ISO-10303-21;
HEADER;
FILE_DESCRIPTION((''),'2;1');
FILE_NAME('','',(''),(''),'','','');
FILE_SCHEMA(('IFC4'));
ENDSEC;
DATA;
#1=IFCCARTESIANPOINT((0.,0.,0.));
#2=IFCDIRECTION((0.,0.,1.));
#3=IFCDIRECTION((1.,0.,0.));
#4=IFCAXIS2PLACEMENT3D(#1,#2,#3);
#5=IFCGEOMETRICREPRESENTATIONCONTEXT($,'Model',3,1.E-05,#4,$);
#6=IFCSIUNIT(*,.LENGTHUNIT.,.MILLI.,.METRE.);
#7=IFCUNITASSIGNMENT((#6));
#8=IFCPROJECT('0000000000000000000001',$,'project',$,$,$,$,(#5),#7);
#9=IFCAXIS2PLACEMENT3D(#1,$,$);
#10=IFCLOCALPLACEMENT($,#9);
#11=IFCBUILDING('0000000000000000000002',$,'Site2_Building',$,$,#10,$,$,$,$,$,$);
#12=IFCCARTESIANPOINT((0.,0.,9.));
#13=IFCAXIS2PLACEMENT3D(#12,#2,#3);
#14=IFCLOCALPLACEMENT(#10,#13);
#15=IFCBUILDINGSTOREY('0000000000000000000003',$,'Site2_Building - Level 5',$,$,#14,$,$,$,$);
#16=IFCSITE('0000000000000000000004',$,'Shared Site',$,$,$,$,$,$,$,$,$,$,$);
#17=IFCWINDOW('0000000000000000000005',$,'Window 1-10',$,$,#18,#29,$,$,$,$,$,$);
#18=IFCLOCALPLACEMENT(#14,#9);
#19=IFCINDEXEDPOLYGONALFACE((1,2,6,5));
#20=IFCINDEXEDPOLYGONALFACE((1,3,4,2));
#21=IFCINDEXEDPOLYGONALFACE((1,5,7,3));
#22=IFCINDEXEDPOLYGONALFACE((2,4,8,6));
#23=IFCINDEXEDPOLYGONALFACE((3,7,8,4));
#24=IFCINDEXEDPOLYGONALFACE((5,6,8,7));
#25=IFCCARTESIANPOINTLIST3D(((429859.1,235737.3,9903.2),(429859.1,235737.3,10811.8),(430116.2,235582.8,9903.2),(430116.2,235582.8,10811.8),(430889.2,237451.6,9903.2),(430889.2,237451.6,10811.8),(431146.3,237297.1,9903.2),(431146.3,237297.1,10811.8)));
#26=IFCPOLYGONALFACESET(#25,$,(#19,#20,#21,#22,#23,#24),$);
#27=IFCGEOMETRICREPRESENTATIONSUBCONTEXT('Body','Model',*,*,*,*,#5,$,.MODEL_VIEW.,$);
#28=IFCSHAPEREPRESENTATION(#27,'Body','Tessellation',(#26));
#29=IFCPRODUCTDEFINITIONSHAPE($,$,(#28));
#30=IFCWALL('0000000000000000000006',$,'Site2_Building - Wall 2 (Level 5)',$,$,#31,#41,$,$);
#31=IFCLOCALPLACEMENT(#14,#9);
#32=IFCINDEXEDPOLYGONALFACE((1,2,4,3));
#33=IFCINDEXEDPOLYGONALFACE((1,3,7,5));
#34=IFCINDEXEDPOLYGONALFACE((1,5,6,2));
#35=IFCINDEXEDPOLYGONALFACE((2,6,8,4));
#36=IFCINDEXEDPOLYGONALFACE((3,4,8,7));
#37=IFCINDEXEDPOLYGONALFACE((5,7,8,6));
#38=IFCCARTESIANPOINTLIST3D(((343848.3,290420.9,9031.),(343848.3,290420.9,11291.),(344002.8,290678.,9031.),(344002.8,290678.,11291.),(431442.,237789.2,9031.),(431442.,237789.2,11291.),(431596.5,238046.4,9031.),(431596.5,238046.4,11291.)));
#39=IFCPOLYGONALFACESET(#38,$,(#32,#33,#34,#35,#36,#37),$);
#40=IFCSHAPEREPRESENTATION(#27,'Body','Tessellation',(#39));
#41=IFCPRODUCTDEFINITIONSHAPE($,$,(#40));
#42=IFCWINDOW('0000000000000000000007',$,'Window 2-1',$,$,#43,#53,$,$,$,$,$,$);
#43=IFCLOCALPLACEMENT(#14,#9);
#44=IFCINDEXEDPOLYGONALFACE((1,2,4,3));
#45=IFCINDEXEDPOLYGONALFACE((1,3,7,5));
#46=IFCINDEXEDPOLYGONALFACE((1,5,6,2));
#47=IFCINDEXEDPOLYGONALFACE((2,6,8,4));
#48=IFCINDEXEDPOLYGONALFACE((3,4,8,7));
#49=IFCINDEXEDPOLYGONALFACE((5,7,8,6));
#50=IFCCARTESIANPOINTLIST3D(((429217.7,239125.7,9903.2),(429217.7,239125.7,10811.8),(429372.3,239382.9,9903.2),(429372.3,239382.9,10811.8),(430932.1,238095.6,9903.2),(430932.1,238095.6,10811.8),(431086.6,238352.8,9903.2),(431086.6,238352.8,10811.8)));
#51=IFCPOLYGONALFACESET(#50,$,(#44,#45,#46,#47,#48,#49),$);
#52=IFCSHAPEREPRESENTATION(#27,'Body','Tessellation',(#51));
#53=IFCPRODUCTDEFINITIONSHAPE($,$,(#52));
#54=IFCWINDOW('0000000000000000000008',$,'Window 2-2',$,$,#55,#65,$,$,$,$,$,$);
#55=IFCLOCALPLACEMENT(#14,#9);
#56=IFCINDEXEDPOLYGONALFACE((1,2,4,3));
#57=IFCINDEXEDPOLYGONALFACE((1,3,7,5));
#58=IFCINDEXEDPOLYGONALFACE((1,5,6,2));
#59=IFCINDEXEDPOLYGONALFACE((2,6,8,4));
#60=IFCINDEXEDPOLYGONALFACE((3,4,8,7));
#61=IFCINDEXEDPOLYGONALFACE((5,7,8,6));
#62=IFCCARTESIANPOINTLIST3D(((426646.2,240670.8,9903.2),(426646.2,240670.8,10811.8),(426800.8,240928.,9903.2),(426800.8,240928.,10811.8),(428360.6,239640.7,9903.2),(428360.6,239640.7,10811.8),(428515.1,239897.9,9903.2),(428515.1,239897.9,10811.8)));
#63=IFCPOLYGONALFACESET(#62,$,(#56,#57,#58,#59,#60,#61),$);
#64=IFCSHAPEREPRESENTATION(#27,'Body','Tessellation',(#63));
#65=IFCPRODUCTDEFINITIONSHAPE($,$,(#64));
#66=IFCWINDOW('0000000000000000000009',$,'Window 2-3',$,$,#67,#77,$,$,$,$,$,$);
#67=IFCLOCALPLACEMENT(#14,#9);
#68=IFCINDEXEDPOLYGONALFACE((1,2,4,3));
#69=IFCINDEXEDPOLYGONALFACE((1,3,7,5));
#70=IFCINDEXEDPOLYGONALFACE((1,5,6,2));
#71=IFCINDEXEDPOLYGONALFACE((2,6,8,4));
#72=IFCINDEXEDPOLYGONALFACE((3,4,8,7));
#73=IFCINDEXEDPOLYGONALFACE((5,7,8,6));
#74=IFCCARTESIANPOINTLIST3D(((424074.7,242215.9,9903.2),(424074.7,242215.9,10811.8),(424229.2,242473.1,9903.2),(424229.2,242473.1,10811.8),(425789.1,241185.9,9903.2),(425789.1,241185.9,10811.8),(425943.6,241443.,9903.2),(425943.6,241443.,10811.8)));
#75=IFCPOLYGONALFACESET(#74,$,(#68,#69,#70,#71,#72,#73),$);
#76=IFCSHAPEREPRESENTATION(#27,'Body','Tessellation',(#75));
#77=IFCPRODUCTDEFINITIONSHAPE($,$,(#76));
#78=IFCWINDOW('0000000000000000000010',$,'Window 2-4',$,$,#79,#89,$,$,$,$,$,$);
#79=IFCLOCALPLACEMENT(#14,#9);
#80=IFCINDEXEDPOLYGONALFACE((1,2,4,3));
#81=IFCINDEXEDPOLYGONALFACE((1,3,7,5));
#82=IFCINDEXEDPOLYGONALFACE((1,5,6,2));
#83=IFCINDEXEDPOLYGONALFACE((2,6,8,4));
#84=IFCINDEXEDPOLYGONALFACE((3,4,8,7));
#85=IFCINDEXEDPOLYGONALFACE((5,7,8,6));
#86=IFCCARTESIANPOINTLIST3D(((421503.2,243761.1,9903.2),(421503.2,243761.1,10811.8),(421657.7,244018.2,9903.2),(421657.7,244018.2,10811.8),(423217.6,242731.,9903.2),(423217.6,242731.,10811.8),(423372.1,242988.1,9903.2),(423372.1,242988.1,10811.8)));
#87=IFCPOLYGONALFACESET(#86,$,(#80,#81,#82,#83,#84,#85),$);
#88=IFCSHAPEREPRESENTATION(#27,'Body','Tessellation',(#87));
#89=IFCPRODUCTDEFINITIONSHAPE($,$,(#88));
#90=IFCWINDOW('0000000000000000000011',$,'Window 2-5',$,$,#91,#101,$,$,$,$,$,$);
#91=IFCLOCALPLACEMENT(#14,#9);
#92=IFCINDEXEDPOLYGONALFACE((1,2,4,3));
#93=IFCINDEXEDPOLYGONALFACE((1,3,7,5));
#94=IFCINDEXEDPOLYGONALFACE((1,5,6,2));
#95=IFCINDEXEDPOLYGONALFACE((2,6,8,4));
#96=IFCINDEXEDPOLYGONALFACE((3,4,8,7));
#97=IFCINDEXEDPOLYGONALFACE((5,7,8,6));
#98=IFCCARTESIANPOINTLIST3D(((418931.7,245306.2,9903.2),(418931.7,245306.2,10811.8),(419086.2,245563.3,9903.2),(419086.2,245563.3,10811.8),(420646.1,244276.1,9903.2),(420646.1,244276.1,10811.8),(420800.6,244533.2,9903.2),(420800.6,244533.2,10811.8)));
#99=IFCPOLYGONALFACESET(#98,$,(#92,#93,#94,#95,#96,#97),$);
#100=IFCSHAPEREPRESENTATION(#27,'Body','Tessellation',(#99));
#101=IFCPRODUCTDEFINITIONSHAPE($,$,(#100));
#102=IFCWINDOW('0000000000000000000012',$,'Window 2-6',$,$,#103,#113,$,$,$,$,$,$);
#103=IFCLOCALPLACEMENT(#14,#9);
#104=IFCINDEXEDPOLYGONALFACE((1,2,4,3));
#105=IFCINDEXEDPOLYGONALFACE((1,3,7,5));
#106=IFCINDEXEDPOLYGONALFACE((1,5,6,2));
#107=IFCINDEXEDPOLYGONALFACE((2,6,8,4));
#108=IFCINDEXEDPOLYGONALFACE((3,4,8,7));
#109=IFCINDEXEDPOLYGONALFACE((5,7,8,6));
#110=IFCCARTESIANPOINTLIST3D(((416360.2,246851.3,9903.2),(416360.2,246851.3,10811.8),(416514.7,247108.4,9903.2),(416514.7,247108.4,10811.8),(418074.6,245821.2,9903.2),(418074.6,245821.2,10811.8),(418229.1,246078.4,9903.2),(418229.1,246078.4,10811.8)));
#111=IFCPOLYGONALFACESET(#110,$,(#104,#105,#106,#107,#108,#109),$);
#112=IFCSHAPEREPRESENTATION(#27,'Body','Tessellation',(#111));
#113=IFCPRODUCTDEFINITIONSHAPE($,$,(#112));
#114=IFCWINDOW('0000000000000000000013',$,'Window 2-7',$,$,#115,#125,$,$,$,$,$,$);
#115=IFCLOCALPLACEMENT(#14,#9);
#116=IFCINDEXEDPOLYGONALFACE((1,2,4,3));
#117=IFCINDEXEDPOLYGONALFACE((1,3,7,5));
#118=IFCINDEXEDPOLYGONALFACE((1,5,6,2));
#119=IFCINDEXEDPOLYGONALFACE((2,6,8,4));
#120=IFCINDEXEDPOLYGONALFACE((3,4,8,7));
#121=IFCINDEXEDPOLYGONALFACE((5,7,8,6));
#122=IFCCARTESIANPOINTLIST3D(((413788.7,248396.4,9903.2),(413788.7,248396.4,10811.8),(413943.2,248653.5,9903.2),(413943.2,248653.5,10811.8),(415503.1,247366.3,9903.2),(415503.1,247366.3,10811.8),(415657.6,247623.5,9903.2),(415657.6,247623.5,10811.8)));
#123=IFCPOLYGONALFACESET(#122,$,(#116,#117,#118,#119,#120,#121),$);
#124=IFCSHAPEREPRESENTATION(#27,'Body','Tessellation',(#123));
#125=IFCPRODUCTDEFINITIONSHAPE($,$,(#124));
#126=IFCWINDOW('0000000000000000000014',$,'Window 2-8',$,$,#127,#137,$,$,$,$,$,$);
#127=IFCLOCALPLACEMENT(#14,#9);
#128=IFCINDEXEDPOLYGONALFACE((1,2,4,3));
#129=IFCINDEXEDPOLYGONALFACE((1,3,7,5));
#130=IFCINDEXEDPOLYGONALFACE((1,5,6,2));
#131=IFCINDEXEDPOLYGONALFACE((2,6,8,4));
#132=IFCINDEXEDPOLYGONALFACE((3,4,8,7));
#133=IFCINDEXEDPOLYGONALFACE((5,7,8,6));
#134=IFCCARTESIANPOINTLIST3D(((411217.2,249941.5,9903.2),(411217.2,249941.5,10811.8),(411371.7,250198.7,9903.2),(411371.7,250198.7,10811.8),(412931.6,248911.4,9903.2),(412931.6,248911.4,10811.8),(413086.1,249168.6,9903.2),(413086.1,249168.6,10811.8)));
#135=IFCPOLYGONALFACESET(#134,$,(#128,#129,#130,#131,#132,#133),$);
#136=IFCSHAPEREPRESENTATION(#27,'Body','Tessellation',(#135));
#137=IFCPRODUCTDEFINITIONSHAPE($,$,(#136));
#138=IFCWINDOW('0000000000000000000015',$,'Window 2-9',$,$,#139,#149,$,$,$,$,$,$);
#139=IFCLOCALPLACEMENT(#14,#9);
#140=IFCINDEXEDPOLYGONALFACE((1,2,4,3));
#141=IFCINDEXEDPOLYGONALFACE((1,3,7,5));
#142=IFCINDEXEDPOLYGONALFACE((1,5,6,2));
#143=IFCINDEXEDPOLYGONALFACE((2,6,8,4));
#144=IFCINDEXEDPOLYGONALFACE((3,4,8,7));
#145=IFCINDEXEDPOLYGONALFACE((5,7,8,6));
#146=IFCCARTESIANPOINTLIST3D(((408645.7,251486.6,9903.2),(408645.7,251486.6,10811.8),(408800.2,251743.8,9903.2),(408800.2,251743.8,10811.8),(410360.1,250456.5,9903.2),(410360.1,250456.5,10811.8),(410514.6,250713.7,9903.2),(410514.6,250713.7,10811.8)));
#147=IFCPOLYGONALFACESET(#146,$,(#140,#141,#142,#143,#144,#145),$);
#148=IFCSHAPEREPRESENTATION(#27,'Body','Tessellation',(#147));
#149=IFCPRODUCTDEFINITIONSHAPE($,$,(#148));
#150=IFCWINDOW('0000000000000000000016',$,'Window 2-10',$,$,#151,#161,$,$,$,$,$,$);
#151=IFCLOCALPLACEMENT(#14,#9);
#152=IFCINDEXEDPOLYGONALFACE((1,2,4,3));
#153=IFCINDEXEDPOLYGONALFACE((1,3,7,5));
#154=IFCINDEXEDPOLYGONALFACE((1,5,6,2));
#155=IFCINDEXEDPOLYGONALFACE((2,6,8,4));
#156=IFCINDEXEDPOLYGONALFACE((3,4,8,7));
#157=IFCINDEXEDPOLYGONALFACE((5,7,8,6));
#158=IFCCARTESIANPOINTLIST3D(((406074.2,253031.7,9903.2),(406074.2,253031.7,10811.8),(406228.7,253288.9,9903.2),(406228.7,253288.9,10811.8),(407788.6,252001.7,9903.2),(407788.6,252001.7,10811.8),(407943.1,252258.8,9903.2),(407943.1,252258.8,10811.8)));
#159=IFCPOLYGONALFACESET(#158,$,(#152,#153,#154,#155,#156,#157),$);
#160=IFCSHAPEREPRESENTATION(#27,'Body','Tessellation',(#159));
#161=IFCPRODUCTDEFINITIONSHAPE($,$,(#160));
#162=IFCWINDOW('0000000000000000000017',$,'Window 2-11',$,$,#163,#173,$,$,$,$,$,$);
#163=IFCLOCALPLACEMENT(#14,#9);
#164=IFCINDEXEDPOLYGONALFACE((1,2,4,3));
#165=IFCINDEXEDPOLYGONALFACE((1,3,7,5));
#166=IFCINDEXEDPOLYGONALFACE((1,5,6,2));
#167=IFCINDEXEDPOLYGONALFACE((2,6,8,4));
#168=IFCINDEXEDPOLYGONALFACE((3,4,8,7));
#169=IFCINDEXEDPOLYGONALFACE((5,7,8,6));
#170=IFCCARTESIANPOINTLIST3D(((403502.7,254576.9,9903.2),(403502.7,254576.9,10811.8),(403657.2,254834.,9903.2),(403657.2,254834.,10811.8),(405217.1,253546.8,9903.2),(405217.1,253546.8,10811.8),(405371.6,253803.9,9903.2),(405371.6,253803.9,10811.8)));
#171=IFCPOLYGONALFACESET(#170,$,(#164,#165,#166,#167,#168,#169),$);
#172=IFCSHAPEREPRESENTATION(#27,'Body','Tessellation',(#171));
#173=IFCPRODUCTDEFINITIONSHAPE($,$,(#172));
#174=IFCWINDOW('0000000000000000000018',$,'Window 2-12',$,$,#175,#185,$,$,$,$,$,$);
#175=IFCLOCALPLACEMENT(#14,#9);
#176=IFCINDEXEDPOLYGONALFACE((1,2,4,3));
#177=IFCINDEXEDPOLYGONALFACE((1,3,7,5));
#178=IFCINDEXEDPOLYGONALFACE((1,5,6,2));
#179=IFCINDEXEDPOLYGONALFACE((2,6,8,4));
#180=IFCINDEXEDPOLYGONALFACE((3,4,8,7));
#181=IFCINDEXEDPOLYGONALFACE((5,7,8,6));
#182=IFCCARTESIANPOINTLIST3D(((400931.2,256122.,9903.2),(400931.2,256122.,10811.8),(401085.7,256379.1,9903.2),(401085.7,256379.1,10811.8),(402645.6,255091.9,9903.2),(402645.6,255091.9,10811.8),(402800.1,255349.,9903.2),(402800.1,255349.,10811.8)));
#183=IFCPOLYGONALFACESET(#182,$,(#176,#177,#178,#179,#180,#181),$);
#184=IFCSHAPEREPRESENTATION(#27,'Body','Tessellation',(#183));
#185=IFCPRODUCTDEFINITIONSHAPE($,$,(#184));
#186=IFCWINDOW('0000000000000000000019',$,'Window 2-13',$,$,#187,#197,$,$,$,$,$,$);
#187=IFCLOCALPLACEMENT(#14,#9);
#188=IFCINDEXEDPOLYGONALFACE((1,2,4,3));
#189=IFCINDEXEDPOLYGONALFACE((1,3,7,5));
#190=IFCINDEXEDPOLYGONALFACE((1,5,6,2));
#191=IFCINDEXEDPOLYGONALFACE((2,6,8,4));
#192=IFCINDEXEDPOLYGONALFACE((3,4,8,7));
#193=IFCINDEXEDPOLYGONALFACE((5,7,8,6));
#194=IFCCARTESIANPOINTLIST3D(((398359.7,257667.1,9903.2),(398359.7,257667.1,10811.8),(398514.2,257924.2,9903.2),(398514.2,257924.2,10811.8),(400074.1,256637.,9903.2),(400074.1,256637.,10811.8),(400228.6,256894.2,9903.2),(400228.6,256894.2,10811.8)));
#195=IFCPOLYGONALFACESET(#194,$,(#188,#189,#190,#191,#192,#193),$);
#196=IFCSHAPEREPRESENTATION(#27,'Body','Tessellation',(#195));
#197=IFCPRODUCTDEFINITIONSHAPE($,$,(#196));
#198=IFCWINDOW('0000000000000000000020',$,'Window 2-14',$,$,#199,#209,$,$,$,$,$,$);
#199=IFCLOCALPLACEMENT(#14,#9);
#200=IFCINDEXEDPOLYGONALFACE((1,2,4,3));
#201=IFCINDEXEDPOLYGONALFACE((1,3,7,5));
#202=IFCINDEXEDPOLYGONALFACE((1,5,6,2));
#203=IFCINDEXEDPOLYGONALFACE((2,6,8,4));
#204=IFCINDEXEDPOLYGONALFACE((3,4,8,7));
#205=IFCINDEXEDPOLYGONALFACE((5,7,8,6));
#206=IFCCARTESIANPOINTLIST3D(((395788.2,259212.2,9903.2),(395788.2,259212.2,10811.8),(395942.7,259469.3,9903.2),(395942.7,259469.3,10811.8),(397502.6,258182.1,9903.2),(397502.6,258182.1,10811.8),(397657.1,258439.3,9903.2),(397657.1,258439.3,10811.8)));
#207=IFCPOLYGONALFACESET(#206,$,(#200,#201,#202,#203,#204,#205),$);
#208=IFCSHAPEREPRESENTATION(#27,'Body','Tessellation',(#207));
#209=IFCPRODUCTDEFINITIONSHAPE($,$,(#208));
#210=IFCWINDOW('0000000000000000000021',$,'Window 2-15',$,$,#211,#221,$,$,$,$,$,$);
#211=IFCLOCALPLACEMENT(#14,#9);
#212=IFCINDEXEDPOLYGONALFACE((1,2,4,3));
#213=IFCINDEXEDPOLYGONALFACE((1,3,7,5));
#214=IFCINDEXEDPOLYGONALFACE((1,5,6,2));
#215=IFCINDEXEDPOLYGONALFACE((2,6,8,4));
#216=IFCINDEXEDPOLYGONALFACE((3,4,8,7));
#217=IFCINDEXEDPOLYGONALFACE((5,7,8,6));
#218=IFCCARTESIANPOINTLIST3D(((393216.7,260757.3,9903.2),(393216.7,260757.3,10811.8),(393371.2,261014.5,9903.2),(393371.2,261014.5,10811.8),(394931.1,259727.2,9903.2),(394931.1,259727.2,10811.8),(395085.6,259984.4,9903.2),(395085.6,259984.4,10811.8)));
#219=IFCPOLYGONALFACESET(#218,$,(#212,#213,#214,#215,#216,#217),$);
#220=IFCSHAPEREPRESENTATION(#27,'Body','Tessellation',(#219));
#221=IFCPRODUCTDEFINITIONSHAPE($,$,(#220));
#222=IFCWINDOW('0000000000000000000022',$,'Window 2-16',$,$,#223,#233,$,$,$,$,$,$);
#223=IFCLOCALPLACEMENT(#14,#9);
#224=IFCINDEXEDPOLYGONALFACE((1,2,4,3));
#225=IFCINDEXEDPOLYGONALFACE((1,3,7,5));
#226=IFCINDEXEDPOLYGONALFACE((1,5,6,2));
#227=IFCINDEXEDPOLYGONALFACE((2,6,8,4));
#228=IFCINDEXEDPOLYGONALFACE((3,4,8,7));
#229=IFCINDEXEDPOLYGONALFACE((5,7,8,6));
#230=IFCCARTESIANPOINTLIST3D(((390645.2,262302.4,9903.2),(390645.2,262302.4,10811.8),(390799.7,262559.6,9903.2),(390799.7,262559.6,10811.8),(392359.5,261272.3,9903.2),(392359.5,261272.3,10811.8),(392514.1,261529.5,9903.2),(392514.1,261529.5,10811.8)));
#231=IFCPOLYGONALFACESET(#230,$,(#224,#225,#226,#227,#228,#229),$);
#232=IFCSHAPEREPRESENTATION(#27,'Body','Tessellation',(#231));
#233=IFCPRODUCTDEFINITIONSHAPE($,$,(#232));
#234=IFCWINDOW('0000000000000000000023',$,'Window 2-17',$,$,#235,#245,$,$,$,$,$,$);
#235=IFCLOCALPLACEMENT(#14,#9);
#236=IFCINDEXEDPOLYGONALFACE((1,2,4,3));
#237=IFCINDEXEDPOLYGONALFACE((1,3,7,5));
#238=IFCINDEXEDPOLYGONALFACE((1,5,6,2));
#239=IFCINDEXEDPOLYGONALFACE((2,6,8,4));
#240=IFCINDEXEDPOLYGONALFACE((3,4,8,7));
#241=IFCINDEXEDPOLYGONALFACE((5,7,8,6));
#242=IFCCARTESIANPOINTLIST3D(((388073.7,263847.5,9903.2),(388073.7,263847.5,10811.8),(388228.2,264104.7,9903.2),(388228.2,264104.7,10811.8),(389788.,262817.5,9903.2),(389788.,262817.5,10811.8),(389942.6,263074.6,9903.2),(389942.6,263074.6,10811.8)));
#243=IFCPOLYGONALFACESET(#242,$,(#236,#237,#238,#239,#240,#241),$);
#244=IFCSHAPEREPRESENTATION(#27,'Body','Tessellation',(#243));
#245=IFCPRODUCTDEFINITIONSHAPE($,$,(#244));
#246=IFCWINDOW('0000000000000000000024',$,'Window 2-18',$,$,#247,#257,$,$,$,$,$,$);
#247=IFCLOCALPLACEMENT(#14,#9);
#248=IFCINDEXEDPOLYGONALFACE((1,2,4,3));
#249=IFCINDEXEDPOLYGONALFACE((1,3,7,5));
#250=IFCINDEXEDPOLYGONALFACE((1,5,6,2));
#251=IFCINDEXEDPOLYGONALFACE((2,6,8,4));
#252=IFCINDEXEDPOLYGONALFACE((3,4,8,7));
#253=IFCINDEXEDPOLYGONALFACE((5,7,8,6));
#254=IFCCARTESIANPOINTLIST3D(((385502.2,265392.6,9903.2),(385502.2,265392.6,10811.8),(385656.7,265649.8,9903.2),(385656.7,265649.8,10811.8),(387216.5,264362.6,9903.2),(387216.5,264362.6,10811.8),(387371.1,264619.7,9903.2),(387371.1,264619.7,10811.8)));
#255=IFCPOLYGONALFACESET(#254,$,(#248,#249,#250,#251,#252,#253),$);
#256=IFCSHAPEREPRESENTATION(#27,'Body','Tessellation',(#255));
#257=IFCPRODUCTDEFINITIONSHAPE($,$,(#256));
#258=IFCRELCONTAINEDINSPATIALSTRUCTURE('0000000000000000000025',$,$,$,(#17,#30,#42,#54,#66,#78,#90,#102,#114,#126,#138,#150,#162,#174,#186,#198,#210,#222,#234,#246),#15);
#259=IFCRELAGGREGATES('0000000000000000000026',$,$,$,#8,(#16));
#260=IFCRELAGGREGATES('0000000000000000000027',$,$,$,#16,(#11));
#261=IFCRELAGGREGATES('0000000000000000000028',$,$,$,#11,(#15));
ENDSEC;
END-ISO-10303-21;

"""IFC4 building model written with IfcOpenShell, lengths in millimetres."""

from ifc_helpers import new_model, si_unit, frame, origin, origin_with_axes, place, context, subcontext, project, spatial, indexed_curve, outline, extrude, element, save


model = new_model("IFC4")

# Units and contexts
model_context = context("Model", 3, precision=1e-05, world=origin_with_axes())
body_context = subcontext(model_context, "Body", "Model", "MODEL_VIEW")
ifc_project = project(units=[si_unit("LENGTHUNIT", "METRE", prefix="MILLI")], contexts=[model_context])

# Site, building, storey
site = spatial("IfcSite", under=ifc_project, Name="Shared Site")
building_placement = place(None, origin())
building = spatial("IfcBuilding", under=site, at=building_placement, Name="Site2_Building")
storey_placement = place(building_placement, frame((0.0, 0.0, 9.0), z_axis=(0.0, 0.0, 1.0), x_axis=(1.0, 0.0, 0.0)))
storey = spatial("IfcBuildingStorey", under=building, at=storey_placement, Name="Site2_Building - Level 5")

# Window
window_placement = place(storey_placement, frame((430116.2, 235582.8, 9903.2), z_axis=(0.0, 0.0, 1.0), x_axis=(0.515038, 0.857167, 0.0)))
element("IfcWindow", 1, at=window_placement, inside=storey, Name="Window 1-10", context=body_context, shape_type="SweptSolid", body=[
    extrude(outline(indexed_curve([(0.0, 0.0), (0.0, 300.0), (2000.0, 300.0), (2000.0, 0.0), (0.0, 0.0)], self_intersect=False)), origin_with_axes(), (0.0, 0.0, 1.0), 908.6),
])

# Wall
wall_placement = place(storey_placement, frame((431596.5, 238046.4, 9031.0), z_axis=(0.0, 0.0, 1.0), x_axis=(-0.857167, 0.515038, 0.0)))
element("IfcWall", 2, at=wall_placement, inside=storey, Name="Site2_Building - Wall 2 (Level 5)", context=body_context, shape_type="SweptSolid", body=[
    extrude(outline(indexed_curve([(0.0, 0.0), (0.0, 300.0), (102189.8, 300.0), (102189.8, 0.0), (0.0, 0.0)], self_intersect=False)), origin_with_axes(), (0.0, 0.0, 1.0), 2260.0),
])

# Windows
for number, where, z_axis, x_axis, name in (
    (3, (431086.6, 238352.8, 9903.2), (0.0, 0.0, 1.0), (-0.857167, 0.515038, 0.0), "Window 2-1"),
    (4, (428515.1, 239897.9, 9903.2), (0.0, 0.0, 1.0), (-0.857167, 0.515038, 0.0), "Window 2-2"),
    (5, (425943.6, 241443.0, 9903.2), (0.0, 0.0, 1.0), (-0.857167, 0.515038, 0.0), "Window 2-3"),
    (6, (423372.1, 242988.1, 9903.2), (0.0, 0.0, 1.0), (-0.857167, 0.515038, 0.0), "Window 2-4"),
    (7, (420800.6, 244533.2, 9903.2), (0.0, 0.0, 1.0), (-0.857167, 0.515038, 0.0), "Window 2-5"),
    (8, (418229.1, 246078.4, 9903.2), (0.0, 0.0, 1.0), (-0.857167, 0.515038, 0.0), "Window 2-6"),
    (9, (415657.6, 247623.5, 9903.2), (0.0, 0.0, 1.0), (-0.857167, 0.515038, 0.0), "Window 2-7"),
    (10, (413086.1, 249168.6, 9903.2), (0.0, 0.0, 1.0), (-0.857167, 0.515038, 0.0), "Window 2-8"),
    (11, (410514.6, 250713.7, 9903.2), (0.0, 0.0, 1.0), (-0.857167, 0.515038, 0.0), "Window 2-9"),
    (12, (407943.1, 252258.8, 9903.2), (0.0, 0.0, 1.0), (-0.857167, 0.515038, 0.0), "Window 2-10"),
    (13, (405371.6, 253803.9, 9903.2), (0.0, 0.0, 1.0), (-0.857167, 0.515038, 0.0), "Window 2-11"),
    (14, (402800.1, 255349.0, 9903.2), (0.0, 0.0, 1.0), (-0.857167, 0.515038, 0.0), "Window 2-12"),
    (15, (400228.6, 256894.2, 9903.2), (0.0, 0.0, 1.0), (-0.857167, 0.515038, 0.0), "Window 2-13"),
    (16, (397657.1, 258439.3, 9903.2), (0.0, 0.0, 1.0), (-0.857167, 0.515038, 0.0), "Window 2-14"),
    (17, (395085.6, 259984.4, 9903.2), (0.0, 0.0, 1.0), (-0.857167, 0.515038, 0.0), "Window 2-15"),
    (18, (392514.1, 261529.5, 9903.2), (0.0, 0.0, 1.0), (-0.857167, 0.515038, 0.0), "Window 2-16"),
    (19, (389942.6, 263074.6, 9903.2), (0.0, 0.0, 1.0), (-0.857167, 0.515038, 0.0), "Window 2-17"),
    (20, (387371.1, 264619.7, 9903.2), (0.0, 0.0, 1.0), (-0.857167, 0.515038, 0.0), "Window 2-18"),
):
    element("IfcWindow", number, at=place(storey_placement, frame(where, z_axis=z_axis, x_axis=x_axis)), inside=storey, Name=name, context=body_context, shape_type="SweptSolid", body=[
        extrude(outline(indexed_curve([(0.0, 0.0), (0.0, 300.0), (2000.0, 300.0), (2000.0, 0.0), (0.0, 0.0)], self_intersect=False)), origin_with_axes(), (0.0, 0.0, 1.0), 908.6),
    ])

save(model, "model.ifc")
